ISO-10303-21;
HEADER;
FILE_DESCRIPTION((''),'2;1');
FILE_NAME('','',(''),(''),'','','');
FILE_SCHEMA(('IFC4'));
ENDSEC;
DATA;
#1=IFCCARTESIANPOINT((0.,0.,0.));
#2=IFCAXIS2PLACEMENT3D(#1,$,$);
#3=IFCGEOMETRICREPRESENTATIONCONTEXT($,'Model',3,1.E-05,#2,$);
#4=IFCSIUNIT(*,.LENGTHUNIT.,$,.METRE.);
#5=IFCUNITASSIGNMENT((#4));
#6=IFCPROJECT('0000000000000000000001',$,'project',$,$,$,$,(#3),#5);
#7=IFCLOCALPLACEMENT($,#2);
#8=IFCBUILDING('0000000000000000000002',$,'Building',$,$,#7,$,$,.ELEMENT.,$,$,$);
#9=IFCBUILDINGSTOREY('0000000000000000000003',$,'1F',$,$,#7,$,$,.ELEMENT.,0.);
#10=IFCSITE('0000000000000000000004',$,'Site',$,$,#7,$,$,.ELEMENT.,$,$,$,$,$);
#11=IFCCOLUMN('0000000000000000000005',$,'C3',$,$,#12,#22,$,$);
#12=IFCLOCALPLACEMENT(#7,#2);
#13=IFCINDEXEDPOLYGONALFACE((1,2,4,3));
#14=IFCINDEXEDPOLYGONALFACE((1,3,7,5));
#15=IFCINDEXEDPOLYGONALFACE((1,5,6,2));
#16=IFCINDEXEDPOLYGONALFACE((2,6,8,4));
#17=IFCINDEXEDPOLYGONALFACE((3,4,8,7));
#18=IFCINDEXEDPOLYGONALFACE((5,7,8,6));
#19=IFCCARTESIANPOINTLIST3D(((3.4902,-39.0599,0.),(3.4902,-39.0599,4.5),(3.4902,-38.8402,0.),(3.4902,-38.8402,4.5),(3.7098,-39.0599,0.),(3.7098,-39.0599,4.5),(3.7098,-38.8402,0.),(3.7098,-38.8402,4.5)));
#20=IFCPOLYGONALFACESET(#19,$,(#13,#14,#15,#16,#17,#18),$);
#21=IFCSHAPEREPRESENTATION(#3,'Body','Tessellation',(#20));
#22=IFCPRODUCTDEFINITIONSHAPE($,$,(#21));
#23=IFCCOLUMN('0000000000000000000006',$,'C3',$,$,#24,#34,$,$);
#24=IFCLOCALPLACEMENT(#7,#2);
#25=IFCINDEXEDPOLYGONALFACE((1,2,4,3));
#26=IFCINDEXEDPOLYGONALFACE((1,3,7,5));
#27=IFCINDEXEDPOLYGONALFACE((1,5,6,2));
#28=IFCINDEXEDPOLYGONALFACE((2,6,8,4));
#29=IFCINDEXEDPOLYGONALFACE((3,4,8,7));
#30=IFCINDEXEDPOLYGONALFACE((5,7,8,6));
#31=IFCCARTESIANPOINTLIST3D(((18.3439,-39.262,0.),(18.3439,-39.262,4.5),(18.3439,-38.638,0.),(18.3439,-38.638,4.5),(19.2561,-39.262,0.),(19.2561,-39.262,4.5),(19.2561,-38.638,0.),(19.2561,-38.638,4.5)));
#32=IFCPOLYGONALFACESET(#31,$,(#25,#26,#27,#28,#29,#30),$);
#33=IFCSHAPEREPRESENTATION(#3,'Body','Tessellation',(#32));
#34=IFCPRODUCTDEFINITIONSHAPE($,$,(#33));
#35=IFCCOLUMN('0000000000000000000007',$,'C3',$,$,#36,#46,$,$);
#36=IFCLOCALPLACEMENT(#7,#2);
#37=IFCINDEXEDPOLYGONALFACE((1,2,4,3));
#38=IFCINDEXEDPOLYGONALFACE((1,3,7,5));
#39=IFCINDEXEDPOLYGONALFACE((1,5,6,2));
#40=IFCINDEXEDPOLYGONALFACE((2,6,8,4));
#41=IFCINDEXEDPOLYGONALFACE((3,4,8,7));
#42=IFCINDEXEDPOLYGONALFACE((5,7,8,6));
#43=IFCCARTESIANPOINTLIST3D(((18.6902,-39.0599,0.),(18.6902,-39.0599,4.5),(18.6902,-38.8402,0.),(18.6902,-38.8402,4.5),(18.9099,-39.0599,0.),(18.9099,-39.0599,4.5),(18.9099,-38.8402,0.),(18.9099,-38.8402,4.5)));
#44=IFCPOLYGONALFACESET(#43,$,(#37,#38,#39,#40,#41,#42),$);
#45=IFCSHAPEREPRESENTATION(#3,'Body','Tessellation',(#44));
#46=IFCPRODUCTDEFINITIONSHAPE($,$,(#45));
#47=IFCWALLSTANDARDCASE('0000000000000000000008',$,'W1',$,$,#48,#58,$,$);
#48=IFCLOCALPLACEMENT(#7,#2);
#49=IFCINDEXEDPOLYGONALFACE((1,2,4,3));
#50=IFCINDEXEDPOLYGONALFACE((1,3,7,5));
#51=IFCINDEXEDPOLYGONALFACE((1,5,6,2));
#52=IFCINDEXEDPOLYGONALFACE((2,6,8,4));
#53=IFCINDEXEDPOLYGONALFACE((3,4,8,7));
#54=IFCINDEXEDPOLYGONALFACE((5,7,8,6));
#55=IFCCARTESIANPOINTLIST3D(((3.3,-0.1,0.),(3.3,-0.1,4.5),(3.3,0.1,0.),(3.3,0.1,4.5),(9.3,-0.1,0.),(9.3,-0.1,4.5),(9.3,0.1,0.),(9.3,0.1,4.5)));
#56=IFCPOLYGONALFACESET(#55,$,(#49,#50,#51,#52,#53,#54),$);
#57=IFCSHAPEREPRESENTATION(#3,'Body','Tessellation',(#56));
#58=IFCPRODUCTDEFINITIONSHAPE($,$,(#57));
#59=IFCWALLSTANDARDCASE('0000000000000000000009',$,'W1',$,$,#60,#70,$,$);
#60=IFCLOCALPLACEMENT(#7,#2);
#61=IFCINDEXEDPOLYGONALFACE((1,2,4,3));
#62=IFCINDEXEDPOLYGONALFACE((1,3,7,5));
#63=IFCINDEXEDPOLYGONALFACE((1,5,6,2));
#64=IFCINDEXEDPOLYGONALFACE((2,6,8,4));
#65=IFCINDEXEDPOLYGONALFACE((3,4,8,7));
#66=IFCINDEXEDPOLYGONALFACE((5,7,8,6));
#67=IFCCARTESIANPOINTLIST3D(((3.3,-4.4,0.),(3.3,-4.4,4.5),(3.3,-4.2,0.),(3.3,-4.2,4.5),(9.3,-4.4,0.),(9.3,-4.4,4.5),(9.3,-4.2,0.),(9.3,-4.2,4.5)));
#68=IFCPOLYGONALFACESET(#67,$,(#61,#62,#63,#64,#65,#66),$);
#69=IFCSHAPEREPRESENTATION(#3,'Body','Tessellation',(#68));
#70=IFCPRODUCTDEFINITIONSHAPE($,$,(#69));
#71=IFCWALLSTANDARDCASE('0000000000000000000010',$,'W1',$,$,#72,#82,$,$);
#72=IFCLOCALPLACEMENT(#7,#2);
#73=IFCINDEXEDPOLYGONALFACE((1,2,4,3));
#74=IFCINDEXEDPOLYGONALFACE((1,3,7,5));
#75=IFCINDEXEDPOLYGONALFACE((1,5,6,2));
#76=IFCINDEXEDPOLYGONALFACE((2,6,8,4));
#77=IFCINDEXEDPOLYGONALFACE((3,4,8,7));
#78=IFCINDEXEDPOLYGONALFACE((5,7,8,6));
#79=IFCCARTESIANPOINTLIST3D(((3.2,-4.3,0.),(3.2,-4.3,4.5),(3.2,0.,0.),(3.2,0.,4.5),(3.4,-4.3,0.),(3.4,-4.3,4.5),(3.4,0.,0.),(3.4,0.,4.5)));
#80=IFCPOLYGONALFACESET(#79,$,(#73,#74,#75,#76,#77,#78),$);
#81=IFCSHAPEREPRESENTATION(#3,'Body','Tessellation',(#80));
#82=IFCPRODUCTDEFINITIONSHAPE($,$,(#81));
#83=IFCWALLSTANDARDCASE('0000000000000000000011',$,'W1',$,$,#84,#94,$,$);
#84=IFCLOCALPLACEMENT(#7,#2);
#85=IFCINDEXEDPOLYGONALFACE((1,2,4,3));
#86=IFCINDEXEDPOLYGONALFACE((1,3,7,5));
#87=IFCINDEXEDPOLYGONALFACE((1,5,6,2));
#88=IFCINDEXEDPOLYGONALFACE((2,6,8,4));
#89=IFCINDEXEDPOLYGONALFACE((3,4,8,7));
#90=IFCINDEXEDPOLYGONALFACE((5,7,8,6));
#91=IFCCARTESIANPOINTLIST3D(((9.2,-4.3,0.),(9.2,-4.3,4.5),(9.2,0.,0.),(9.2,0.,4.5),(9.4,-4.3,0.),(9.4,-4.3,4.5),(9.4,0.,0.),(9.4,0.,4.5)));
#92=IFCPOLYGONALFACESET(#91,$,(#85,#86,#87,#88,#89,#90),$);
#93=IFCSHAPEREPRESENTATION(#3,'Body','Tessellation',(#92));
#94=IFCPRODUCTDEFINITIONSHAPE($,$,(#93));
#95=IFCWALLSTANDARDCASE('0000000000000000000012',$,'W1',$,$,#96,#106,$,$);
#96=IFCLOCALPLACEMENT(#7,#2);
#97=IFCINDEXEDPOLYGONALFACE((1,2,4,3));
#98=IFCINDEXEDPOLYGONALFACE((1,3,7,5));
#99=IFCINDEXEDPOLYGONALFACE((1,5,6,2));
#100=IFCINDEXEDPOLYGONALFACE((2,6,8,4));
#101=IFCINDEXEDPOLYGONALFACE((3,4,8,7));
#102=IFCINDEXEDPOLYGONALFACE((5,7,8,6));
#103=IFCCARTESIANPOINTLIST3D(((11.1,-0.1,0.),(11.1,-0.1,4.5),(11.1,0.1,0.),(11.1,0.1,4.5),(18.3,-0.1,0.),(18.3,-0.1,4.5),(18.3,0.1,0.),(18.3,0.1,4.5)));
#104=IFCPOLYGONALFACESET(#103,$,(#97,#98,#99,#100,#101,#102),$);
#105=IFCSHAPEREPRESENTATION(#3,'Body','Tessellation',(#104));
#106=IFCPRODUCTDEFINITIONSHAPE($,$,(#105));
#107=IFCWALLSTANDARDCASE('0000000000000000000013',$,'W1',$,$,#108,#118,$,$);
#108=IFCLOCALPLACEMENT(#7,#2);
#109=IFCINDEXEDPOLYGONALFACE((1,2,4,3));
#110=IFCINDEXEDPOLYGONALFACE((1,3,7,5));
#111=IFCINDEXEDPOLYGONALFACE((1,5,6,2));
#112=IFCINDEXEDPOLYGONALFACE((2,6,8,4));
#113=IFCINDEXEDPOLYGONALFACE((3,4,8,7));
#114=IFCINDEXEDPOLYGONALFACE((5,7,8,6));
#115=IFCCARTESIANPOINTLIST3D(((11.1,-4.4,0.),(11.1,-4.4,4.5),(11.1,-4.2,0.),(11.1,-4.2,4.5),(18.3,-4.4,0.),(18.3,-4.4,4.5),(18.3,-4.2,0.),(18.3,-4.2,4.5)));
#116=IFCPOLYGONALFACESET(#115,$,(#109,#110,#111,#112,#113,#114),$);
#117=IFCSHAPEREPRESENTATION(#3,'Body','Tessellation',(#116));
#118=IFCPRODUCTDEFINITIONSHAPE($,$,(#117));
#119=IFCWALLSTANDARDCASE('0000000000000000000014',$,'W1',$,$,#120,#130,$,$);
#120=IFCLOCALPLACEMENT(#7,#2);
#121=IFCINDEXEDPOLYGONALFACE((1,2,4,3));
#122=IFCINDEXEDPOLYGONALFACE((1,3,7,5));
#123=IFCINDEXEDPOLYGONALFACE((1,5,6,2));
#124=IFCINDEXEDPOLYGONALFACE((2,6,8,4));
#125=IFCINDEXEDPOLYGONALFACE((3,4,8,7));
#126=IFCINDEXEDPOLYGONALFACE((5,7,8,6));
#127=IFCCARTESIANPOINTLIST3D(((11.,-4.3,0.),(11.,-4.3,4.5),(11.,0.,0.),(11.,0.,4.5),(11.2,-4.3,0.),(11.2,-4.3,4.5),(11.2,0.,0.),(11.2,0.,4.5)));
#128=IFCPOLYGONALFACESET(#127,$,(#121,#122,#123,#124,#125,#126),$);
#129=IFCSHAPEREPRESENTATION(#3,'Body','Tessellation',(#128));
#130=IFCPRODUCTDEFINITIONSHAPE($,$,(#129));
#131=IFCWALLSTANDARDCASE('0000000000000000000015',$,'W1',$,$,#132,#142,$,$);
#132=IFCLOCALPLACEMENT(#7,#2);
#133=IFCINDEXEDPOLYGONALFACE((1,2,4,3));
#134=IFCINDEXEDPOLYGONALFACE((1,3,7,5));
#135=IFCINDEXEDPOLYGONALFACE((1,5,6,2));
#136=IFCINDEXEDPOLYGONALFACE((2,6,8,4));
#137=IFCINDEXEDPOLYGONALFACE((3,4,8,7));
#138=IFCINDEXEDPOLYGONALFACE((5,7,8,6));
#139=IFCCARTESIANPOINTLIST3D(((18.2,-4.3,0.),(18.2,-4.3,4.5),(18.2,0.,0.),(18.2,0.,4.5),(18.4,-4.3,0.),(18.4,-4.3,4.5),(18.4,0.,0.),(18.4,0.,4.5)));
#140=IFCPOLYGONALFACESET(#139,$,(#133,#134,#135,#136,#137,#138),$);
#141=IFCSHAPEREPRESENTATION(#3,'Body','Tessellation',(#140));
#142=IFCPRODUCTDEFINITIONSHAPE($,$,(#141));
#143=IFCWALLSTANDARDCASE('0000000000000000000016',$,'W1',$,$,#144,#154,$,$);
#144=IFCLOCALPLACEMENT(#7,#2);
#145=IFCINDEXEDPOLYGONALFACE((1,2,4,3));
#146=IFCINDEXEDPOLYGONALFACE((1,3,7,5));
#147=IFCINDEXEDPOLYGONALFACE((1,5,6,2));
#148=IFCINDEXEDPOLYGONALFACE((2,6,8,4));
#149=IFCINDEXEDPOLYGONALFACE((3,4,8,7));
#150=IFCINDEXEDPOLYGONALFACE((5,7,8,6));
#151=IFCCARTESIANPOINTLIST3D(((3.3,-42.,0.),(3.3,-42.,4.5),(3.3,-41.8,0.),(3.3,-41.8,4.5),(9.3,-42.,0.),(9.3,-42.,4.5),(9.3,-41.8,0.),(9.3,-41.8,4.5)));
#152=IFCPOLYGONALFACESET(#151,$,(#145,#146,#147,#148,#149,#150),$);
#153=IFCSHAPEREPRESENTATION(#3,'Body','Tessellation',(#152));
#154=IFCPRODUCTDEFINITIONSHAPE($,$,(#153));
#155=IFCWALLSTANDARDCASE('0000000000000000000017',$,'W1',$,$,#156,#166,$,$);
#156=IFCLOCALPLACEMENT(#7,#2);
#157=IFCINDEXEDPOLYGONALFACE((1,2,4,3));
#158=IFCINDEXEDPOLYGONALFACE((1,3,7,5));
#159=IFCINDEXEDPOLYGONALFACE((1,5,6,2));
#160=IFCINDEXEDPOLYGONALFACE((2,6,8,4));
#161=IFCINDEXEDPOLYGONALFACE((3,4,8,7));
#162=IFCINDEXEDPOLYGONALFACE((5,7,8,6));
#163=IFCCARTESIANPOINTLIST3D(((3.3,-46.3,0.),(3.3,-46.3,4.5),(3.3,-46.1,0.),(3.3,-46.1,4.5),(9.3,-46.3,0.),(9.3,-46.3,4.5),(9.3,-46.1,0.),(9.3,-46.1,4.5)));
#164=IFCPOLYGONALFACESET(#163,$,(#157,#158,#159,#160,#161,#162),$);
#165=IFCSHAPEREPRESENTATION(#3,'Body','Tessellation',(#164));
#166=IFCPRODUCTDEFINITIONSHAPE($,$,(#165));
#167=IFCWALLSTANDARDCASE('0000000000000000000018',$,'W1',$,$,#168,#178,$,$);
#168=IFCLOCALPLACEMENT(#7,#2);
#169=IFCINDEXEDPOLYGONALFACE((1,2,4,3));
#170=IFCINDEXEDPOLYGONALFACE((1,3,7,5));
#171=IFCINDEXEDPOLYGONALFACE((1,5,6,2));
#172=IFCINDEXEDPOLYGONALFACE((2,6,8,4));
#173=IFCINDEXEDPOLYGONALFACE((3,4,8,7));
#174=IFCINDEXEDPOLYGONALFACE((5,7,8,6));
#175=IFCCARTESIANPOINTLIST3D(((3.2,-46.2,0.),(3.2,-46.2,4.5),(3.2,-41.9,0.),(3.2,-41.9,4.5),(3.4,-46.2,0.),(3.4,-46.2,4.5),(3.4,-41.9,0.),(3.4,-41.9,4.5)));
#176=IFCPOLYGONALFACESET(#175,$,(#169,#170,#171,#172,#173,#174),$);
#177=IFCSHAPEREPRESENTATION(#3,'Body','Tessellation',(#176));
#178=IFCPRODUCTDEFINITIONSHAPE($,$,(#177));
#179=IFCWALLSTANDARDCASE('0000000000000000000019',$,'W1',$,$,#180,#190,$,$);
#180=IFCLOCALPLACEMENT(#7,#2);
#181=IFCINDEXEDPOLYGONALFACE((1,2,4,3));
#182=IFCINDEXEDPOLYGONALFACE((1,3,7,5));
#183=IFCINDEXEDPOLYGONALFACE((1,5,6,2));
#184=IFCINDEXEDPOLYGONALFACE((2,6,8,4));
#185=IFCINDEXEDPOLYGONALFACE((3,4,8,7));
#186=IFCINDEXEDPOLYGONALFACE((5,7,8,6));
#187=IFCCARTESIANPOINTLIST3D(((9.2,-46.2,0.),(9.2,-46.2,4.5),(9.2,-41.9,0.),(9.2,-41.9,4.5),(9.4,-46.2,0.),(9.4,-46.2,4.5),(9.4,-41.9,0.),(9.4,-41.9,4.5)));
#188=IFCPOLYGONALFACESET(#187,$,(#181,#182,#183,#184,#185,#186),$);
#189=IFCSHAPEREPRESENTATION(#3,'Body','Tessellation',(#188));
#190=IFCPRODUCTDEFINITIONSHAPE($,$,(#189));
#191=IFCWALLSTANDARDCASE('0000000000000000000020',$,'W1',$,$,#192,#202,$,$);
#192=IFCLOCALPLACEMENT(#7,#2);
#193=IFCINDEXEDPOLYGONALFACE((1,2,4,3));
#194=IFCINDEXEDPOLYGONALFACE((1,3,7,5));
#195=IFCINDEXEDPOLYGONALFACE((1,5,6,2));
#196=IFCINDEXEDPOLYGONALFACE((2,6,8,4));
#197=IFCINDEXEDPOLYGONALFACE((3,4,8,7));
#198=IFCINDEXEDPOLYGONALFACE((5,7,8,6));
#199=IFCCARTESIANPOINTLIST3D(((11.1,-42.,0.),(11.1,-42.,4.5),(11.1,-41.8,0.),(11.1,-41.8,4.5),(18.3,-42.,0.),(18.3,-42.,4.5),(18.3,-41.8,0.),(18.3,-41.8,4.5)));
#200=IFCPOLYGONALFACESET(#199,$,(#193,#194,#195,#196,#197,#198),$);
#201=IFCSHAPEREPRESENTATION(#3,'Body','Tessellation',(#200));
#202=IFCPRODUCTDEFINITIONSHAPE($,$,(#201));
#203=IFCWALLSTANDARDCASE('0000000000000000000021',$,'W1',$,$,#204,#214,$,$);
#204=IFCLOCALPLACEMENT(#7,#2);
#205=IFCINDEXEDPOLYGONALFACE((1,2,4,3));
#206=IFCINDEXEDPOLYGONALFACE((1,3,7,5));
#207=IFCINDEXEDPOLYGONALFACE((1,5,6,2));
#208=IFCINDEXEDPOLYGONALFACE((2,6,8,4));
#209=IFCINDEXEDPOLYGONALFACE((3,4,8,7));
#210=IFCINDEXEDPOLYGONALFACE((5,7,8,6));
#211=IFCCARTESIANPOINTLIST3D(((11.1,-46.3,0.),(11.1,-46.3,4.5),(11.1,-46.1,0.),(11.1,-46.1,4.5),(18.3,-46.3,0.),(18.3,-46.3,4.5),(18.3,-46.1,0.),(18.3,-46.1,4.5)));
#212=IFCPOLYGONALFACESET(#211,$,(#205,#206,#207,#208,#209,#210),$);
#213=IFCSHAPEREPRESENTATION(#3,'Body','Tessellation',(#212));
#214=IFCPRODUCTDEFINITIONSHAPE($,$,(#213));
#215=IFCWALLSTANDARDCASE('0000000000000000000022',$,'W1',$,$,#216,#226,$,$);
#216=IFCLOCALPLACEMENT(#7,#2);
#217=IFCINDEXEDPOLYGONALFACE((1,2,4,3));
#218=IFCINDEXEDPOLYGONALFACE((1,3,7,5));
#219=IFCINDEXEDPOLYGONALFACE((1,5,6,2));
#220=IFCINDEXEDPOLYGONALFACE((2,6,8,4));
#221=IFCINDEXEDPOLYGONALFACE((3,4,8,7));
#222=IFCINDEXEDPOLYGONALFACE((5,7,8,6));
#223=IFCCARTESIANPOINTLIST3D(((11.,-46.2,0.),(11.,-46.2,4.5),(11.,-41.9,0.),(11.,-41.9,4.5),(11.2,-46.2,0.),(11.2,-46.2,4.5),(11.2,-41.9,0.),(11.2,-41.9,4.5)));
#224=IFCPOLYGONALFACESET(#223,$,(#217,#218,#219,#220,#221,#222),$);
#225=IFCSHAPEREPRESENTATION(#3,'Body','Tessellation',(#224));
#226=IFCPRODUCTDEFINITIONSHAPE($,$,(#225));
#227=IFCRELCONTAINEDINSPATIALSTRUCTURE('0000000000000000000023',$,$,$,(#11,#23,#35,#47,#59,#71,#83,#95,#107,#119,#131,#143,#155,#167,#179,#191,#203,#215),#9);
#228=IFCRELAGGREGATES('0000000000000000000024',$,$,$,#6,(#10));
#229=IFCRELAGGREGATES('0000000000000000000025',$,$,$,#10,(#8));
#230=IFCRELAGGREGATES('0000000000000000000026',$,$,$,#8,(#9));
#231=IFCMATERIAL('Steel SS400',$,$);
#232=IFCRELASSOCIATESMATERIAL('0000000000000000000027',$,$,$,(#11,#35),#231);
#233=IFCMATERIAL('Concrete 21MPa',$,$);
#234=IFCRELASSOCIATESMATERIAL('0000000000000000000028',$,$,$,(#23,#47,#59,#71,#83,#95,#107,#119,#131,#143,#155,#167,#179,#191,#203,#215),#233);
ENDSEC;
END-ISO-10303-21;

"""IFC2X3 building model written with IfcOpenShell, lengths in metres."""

from ifc_helpers import new_model, si_unit, frame, origin, origin_2d, place, context, project, spatial, rectangle, extrude, material, element, save


model = new_model("IFC2X3")

# Units and contexts
model_context = context("Model", 3, precision=1e-05, world=origin())
ifc_project = project(units=[si_unit("LENGTHUNIT", "METRE")], contexts=[model_context])

# Site, building, storey
placement = place(None, origin())
site = spatial("IfcSite", under=ifc_project, at=placement, Name="Site", CompositionType="ELEMENT")
building = spatial("IfcBuilding", under=site, at=placement, Name="Building", CompositionType="ELEMENT")
storey = spatial("IfcBuildingStorey", under=building, at=placement, Name="1F", CompositionType="ELEMENT", Elevation=0.0)

# Columns
ifc_material_1 = material(Name="Concrete 21MPa")
ifc_material_2 = material(Name="Steel SS400")
column_1_placement = place(None, frame((3.6, -38.95, 0.0)))
element("IfcColumn", 1, at=column_1_placement, inside=storey, material=ifc_material_2, Name="C3", context=model_context, shape_type="SweptSolid", body=[
    extrude(rectangle(XDim=0.2197, YDim=0.2197, at=origin_2d()), origin(), (0.0, 0.0, 1.0), 4.5),
])
column_2_placement = place(None, frame((18.8, -38.95, 0.0)))
element("IfcColumn", 2, at=column_2_placement, inside=storey, material=ifc_material_1, Name="C3", context=model_context, shape_type="SweptSolid", body=[
    extrude(rectangle(XDim=0.9121, YDim=0.6241, at=origin_2d()), origin(), (0.0, 0.0, 1.0), 4.5),
])
column_3_placement = place(None, frame((18.8, -38.95, 0.0)))
element("IfcColumn", 3, at=column_3_placement, inside=storey, material=ifc_material_2, Name="C3", context=model_context, shape_type="SweptSolid", body=[
    extrude(rectangle(XDim=0.2197, YDim=0.2197, at=origin_2d()), origin(), (0.0, 0.0, 1.0), 4.5),
])

# Walls
for number, where, name in (
    (4, (6.3, 0.0, 0.0), "W1"),
    (5, (6.3, -4.3, 0.0), "W1"),
):
    element("IfcWallStandardCase", number, at=place(None, frame(where)), inside=storey, material=ifc_material_1, Name=name, context=model_context, shape_type="SweptSolid", body=[
        extrude(rectangle(XDim=6.0, YDim=0.2, at=origin_2d()), origin(), (0.0, 0.0, 1.0), 4.5),
    ])
for number, where, name in (
    (6, (3.3, -2.15, 0.0), "W1"),
    (7, (9.3, -2.15, 0.0), "W1"),
):
    element("IfcWallStandardCase", number, at=place(None, frame(where)), inside=storey, material=ifc_material_1, Name=name, context=model_context, shape_type="SweptSolid", body=[
        extrude(rectangle(XDim=0.2, YDim=4.3, at=origin_2d()), origin(), (0.0, 0.0, 1.0), 4.5),
    ])
for number, where, name in (
    (8, (14.7, 0.0, 0.0), "W1"),
    (9, (14.7, -4.3, 0.0), "W1"),
):
    element("IfcWallStandardCase", number, at=place(None, frame(where)), inside=storey, material=ifc_material_1, Name=name, context=model_context, shape_type="SweptSolid", body=[
        extrude(rectangle(XDim=7.2, YDim=0.2, at=origin_2d()), origin(), (0.0, 0.0, 1.0), 4.5),
    ])
for number, where, name in (
    (10, (11.1, -2.15, 0.0), "W1"),
    (11, (18.3, -2.15, 0.0), "W1"),
):
    element("IfcWallStandardCase", number, at=place(None, frame(where)), inside=storey, material=ifc_material_1, Name=name, context=model_context, shape_type="SweptSolid", body=[
        extrude(rectangle(XDim=0.2, YDim=4.3, at=origin_2d()), origin(), (0.0, 0.0, 1.0), 4.5),
    ])
for number, where, name in (
    (12, (6.3, -41.9, 0.0), "W1"),
    (13, (6.3, -46.2, 0.0), "W1"),
):
    element("IfcWallStandardCase", number, at=place(None, frame(where)), inside=storey, material=ifc_material_1, Name=name, context=model_context, shape_type="SweptSolid", body=[
        extrude(rectangle(XDim=6.0, YDim=0.2, at=origin_2d()), origin(), (0.0, 0.0, 1.0), 4.5),
    ])
for number, where, name in (
    (14, (3.3, -44.05, 0.0), "W1"),
    (15, (9.3, -44.05, 0.0), "W1"),
):
    element("IfcWallStandardCase", number, at=place(None, frame(where)), inside=storey, material=ifc_material_1, Name=name, context=model_context, shape_type="SweptSolid", body=[
        extrude(rectangle(XDim=0.2, YDim=4.3, at=origin_2d()), origin(), (0.0, 0.0, 1.0), 4.5),
    ])
for number, where, name in (
    (16, (14.7, -41.9, 0.0), "W1"),
    (17, (14.7, -46.2, 0.0), "W1"),
):
    element("IfcWallStandardCase", number, at=place(None, frame(where)), inside=storey, material=ifc_material_1, Name=name, context=model_context, shape_type="SweptSolid", body=[
        extrude(rectangle(XDim=7.2, YDim=0.2, at=origin_2d()), origin(), (0.0, 0.0, 1.0), 4.5),
    ])
for number, where, name in (
    (18, (11.1, -44.05, 0.0), "W1"),
):
    element("IfcWallStandardCase", number, at=place(None, frame(where)), inside=storey, material=ifc_material_1, Name=name, context=model_context, shape_type="SweptSolid", body=[
        extrude(rectangle(XDim=0.2, YDim=4.3, at=origin_2d()), origin(), (0.0, 0.0, 1.0), 4.5),
    ])

save(model, "model.ifc")
